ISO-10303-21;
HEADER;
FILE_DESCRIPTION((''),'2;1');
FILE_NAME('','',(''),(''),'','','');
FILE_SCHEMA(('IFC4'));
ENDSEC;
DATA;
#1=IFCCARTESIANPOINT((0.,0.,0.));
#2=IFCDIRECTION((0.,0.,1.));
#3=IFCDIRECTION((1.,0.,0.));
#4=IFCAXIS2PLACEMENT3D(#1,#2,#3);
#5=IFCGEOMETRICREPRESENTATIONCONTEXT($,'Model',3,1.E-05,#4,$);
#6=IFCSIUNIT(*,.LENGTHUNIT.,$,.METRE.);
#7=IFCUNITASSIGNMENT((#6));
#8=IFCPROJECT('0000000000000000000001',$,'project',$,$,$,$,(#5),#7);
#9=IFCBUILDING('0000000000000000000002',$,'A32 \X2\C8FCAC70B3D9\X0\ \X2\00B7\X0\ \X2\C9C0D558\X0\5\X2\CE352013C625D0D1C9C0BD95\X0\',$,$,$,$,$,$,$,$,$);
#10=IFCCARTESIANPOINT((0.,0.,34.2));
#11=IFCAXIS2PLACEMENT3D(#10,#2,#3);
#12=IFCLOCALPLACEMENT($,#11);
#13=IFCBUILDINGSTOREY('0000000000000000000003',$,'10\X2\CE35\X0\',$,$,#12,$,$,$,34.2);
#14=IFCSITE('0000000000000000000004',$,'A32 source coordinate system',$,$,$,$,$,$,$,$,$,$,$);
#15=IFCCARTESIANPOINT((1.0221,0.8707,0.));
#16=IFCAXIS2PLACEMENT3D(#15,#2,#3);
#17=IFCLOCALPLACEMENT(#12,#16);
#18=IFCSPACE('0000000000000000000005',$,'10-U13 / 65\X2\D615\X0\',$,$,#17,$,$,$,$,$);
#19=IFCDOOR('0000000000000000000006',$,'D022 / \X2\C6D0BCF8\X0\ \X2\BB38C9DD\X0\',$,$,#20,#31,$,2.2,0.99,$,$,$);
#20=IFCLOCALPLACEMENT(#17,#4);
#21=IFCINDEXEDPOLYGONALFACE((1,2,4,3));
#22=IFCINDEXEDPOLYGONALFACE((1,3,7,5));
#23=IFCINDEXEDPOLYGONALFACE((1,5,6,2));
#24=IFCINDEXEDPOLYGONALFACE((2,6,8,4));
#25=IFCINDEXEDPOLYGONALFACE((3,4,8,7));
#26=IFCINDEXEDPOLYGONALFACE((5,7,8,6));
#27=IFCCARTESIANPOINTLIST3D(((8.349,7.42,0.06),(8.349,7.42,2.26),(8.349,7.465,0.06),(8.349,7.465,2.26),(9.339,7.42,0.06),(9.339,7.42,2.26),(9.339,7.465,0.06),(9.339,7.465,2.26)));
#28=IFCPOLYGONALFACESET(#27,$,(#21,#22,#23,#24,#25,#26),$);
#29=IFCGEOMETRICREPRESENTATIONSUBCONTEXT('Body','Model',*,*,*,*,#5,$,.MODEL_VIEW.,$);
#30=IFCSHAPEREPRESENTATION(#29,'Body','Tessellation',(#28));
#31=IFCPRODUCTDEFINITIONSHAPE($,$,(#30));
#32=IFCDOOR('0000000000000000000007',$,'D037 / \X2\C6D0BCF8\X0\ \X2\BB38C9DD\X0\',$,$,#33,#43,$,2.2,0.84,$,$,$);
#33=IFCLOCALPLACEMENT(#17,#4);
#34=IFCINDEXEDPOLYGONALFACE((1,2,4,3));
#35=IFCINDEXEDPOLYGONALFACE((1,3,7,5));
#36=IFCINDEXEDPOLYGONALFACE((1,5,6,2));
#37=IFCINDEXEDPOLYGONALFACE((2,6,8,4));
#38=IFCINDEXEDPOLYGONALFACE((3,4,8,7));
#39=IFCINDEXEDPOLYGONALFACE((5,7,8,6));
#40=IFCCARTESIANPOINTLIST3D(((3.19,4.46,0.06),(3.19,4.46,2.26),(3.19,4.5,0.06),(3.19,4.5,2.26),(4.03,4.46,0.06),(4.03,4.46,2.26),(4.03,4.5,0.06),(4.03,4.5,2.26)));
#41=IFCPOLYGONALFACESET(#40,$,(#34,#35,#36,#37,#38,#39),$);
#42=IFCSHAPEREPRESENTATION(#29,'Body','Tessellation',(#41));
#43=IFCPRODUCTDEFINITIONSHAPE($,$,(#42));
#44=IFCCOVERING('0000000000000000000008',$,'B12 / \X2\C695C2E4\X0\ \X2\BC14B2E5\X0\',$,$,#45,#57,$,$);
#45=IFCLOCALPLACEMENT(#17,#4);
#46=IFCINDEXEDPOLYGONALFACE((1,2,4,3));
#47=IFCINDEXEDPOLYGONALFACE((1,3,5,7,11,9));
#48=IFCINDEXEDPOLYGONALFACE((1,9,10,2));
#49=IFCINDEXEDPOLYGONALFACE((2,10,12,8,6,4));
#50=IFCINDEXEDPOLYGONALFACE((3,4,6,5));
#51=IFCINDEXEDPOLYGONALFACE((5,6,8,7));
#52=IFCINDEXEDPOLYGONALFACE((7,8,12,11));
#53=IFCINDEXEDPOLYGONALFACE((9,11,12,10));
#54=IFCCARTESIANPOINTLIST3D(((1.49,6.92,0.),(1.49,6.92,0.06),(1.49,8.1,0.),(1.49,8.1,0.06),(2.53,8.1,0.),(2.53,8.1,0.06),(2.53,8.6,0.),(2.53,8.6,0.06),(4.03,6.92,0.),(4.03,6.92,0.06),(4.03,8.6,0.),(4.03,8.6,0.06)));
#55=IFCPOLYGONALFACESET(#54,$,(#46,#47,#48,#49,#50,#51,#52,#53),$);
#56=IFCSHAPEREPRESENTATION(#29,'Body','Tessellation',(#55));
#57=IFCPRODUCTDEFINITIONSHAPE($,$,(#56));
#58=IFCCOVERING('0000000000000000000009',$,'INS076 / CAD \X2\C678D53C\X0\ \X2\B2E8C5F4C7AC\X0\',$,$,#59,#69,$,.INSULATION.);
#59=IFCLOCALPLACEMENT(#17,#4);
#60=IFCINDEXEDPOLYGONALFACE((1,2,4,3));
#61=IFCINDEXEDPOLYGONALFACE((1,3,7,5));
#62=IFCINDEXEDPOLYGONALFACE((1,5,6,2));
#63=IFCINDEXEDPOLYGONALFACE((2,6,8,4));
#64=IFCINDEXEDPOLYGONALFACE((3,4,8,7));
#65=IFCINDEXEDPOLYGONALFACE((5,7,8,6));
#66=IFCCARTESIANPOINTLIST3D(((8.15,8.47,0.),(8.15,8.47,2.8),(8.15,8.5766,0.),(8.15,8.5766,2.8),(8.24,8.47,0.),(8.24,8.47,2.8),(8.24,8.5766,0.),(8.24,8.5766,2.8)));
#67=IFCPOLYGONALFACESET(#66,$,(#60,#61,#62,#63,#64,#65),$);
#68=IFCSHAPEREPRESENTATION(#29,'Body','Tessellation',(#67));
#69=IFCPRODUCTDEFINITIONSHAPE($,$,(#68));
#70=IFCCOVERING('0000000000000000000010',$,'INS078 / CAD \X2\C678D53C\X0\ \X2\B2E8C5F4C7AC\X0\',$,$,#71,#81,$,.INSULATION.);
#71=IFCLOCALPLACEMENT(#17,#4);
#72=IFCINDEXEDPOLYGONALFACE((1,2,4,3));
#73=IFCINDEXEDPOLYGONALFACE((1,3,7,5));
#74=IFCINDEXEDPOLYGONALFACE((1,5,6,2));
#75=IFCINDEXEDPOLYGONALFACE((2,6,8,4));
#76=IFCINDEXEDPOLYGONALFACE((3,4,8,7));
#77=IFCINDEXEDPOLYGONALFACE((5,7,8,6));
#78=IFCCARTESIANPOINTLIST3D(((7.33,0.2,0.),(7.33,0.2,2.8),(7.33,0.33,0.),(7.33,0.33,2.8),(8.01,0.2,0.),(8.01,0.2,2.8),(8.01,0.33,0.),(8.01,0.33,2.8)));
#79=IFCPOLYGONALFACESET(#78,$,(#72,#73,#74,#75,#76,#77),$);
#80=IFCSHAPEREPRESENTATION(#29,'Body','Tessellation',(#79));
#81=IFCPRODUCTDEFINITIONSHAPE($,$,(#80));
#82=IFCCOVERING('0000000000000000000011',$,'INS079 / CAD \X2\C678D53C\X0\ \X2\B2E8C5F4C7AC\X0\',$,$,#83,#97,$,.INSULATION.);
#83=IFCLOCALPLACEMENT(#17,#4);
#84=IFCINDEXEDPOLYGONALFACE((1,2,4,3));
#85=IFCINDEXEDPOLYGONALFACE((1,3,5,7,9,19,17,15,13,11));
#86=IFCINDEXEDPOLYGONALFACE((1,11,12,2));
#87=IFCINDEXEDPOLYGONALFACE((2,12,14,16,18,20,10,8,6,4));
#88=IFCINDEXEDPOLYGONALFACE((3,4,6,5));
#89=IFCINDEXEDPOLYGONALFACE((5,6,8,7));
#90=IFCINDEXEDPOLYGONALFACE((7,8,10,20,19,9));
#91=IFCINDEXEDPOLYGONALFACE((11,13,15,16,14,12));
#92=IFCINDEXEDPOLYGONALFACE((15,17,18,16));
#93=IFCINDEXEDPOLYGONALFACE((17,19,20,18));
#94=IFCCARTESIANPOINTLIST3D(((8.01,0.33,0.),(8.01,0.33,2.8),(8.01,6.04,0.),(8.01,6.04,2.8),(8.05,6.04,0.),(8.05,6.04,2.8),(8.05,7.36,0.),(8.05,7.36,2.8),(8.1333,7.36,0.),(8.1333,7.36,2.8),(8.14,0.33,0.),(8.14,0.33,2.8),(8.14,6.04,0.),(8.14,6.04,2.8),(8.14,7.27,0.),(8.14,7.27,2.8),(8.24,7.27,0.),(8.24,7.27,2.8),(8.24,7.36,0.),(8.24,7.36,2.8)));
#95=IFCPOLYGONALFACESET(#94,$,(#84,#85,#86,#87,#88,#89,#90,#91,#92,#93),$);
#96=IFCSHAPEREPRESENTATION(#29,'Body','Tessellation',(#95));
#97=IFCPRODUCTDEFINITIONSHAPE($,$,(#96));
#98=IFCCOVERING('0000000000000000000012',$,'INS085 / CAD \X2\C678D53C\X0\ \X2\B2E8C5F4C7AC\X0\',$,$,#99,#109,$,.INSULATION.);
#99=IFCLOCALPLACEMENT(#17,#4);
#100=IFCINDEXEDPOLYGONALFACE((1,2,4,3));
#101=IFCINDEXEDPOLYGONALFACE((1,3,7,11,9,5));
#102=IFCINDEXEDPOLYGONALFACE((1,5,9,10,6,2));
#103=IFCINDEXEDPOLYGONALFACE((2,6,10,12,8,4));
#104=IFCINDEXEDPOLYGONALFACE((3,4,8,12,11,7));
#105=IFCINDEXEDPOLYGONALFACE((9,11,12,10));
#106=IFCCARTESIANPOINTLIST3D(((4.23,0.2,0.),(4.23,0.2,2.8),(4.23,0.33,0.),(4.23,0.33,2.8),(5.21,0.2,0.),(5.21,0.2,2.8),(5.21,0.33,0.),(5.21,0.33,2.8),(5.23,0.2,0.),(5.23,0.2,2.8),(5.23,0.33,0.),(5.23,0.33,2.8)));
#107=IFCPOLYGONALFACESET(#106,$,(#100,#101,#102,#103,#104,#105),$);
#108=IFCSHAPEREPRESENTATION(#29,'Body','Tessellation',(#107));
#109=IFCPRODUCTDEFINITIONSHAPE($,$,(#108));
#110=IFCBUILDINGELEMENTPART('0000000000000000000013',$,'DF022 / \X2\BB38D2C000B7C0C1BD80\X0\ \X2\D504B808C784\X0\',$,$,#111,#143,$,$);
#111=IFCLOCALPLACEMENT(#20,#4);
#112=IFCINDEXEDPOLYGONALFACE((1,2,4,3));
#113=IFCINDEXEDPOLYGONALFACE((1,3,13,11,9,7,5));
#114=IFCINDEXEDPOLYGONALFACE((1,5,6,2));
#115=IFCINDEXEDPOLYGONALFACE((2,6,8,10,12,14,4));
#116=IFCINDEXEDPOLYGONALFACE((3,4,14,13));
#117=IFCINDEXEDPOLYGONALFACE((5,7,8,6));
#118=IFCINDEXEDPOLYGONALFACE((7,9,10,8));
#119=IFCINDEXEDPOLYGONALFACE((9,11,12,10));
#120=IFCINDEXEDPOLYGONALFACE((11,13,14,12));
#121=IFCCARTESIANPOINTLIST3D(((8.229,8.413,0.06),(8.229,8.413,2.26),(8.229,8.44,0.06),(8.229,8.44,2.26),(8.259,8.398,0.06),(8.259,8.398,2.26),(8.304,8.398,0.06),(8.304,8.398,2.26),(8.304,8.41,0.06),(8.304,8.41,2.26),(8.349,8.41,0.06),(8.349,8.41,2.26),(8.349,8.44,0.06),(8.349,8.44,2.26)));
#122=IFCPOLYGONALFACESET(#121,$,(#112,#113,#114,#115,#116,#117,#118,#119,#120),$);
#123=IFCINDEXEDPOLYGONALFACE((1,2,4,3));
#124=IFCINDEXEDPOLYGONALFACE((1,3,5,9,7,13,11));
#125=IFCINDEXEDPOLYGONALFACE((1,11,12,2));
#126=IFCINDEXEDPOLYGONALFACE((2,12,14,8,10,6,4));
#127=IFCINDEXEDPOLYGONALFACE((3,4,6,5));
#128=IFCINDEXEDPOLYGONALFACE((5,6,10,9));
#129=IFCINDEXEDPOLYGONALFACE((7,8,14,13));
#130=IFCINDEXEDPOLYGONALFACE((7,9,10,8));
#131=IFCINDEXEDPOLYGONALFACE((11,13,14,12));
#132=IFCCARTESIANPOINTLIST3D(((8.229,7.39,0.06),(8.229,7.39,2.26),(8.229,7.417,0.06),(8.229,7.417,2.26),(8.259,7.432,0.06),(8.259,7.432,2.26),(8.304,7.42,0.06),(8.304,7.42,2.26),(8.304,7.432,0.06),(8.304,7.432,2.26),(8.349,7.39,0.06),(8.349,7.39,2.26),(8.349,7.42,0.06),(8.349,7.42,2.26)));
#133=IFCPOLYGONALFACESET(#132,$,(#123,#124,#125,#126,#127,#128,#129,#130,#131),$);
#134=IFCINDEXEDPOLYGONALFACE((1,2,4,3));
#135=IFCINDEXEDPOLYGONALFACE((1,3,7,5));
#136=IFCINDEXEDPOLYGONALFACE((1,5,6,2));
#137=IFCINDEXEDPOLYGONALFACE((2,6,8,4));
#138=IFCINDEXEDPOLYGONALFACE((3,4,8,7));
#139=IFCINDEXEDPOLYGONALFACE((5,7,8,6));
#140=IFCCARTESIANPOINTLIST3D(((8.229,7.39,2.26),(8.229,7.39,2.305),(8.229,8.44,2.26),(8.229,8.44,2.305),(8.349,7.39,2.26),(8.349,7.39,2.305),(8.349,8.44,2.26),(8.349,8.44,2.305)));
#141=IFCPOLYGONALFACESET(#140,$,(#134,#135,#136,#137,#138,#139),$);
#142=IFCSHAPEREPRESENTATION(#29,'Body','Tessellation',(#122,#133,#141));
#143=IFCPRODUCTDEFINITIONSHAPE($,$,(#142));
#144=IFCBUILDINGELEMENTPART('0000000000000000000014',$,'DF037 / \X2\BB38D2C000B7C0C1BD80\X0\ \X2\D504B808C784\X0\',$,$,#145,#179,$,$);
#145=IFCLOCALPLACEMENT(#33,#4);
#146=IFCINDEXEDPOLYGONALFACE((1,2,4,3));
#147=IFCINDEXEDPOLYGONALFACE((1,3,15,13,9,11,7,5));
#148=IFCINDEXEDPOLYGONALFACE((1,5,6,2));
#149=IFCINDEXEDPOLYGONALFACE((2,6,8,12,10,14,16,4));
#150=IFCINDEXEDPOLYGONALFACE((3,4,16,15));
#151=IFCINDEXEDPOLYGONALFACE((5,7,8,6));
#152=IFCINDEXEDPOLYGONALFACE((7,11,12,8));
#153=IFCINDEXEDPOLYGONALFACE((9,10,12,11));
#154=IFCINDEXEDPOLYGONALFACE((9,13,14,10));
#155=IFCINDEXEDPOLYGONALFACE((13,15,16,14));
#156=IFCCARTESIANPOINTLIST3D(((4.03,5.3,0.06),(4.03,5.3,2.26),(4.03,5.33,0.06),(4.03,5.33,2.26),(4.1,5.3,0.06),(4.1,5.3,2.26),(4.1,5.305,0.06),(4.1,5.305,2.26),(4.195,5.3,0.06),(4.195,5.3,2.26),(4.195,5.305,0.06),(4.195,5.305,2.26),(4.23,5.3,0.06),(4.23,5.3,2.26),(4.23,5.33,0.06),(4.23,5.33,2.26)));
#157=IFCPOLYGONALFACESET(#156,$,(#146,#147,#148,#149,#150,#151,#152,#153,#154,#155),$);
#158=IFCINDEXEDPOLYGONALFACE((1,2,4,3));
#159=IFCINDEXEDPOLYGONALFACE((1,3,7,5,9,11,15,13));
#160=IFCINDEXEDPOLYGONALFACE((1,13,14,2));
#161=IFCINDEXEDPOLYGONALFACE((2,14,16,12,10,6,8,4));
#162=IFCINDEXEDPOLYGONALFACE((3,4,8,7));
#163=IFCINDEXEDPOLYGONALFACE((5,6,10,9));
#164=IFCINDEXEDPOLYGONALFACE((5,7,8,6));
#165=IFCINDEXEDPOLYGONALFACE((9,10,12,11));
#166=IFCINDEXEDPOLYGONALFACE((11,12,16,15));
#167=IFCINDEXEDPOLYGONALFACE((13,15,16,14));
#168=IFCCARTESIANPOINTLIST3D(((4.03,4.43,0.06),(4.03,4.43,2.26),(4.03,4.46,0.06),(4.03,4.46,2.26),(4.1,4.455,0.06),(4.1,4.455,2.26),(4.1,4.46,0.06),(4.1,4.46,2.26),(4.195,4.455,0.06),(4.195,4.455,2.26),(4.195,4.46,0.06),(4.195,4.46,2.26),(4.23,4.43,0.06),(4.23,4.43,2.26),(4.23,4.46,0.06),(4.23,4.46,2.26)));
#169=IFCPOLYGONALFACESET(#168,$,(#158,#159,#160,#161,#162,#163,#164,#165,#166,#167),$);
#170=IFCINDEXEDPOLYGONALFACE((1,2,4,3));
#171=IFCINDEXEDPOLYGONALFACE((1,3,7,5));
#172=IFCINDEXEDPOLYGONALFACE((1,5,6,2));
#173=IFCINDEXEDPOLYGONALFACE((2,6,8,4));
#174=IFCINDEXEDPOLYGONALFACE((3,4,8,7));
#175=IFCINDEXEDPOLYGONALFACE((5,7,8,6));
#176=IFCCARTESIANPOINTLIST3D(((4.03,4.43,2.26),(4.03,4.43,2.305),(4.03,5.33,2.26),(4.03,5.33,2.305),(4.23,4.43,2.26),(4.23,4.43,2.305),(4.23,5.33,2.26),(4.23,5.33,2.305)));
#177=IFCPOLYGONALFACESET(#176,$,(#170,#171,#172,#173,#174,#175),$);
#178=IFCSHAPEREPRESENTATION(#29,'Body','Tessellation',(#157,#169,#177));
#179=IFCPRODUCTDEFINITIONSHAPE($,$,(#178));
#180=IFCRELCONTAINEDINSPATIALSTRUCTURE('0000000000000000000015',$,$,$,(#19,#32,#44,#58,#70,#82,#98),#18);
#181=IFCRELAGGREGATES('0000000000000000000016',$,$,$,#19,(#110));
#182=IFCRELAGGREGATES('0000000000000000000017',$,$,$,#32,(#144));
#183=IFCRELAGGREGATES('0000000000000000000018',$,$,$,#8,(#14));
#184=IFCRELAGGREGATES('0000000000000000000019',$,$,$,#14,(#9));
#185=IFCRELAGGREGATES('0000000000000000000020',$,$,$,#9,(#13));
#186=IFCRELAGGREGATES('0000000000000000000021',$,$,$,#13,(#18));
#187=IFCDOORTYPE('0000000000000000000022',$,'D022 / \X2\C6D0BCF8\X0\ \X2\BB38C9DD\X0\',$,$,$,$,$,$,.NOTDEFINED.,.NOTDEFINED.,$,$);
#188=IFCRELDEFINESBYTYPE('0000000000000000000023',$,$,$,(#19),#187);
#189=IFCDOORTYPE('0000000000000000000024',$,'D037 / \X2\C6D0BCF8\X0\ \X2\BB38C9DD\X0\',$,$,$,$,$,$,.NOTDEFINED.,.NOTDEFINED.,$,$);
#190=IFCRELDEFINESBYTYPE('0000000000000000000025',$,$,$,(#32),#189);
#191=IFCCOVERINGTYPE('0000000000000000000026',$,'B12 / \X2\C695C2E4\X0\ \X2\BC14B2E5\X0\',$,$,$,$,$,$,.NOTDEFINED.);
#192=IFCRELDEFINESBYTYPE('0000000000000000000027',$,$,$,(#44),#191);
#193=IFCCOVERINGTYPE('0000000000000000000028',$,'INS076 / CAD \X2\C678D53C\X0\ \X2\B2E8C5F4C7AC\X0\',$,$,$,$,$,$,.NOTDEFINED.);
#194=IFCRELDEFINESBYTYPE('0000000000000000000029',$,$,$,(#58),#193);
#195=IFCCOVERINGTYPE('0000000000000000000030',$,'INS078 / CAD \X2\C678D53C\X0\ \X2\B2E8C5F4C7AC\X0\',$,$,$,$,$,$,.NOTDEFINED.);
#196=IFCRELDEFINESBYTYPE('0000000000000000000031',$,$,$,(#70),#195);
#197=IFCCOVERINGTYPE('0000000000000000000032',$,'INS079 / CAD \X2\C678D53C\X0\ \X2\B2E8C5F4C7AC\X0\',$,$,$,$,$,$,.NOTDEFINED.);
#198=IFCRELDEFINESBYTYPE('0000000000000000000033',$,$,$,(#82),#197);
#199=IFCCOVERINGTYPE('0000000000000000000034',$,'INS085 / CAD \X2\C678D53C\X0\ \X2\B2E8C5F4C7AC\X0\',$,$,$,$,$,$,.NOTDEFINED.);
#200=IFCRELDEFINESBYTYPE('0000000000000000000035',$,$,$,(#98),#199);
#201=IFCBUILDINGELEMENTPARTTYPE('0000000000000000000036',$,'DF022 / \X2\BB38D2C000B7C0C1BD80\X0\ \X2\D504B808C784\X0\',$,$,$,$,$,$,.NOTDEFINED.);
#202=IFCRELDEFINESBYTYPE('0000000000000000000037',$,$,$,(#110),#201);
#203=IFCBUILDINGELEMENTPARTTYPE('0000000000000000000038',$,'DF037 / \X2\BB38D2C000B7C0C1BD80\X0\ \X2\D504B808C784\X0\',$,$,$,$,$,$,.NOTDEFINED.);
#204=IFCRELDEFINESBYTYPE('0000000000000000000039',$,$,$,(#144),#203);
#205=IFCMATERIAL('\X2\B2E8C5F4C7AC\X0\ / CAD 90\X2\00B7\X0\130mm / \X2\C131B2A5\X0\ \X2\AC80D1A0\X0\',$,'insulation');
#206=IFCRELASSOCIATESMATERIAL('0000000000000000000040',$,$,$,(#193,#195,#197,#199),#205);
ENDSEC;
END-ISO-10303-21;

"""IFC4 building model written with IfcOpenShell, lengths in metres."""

from ifc_helpers import new_model, si_unit, frame, origin, origin_with_axes, place, context, subcontext, project, spatial, polyline, outline, extrude, source, transform, mapped, material, type_object, type_shapes, element, aggregate, save


model = new_model("IFC4")

# Units and contexts
model_context = context("Model", 3, precision=1e-05, world=origin_with_axes())
body_context = subcontext(model_context, "Body", "Model", "MODEL_VIEW")
ifc_project = project(units=[si_unit("LENGTHUNIT", "METRE")], contexts=[model_context])

# Site, building, storey
site = spatial("IfcSite", under=ifc_project, Name="A32 source coordinate system")
building = spatial("IfcBuilding", under=site, Name="A32 주거동 · 지하5층–옥탑지붕")
storey_placement = place(None, frame((0.0, 0.0, 34.2), z_axis=(0.0, 0.0, 1.0), x_axis=(1.0, 0.0, 0.0)))
storey = spatial("IfcBuildingStorey", under=building, at=storey_placement, Name="10층", Elevation=34.2)

# Shared definitions
space_placement = place(storey_placement, frame((1.0221, 0.8707, 0.0), z_axis=(0.0, 0.0, 1.0), x_axis=(1.0, 0.0, 0.0)))
space = spatial("IfcSpace", under=storey, at=space_placement, Name="10-U13 / 65형")

# Doors
door_type_1 = type_object("IfcDoorType", Name="D022 / 원본 문짝", OperationType="NOTDEFINED", PredefinedType="NOTDEFINED")
shared_shape_1 = source(origin(), body_context, "Body", "SweptSolid", [
    extrude(outline(polyline([(9.339, 7.465), (9.339, 7.42), (8.349, 7.42), (8.349, 7.465), (9.339, 7.465)])), frame((0.0, 0.0, 0.06)), (0.0, 0.0, 1.0), 2.2),
])
type_shapes(door_type_1, [shared_shape_1])
door_1_placement = place(space_placement, origin_with_axes())
door_1 = element("IfcDoor", 1, at=door_1_placement, inside=space, type_object=door_type_1, Name="D022 / 원본 문짝", OverallHeight=2.2, OverallWidth=0.99, context=body_context, shape_type="MappedRepresentation", body=[
    mapped(shared_shape_1, transform((0.0, 0.0, 0.0), scale=1.0)),
])
door_type_2 = type_object("IfcDoorType", Name="D037 / 원본 문짝", OperationType="NOTDEFINED", PredefinedType="NOTDEFINED")
shared_shape_2 = source(origin(), body_context, "Body", "SweptSolid", [
    extrude(outline(polyline([(4.03, 4.46), (3.19, 4.46), (3.19, 4.5), (4.03, 4.5), (4.03, 4.46)])), frame((0.0, 0.0, 0.06)), (0.0, 0.0, 1.0), 2.2),
])
type_shapes(door_type_2, [shared_shape_2])
door_2_placement = place(space_placement, origin_with_axes())
door_2 = element("IfcDoor", 2, at=door_2_placement, inside=space, type_object=door_type_2, Name="D037 / 원본 문짝", OverallHeight=2.2, OverallWidth=0.84, context=body_context, shape_type="MappedRepresentation", body=[
    mapped(shared_shape_2, transform((0.0, 0.0, 0.0), scale=1.0)),
])

# Coverings
covering_type_1 = type_object("IfcCoveringType", Name="B12 / 욕실 바닥", PredefinedType="NOTDEFINED")
shared_shape_3 = source(origin(), body_context, "Body", "SweptSolid", [
    extrude(outline(polyline([(2.53, 8.6), (4.03, 8.6), (4.03, 6.92), (1.49, 6.92), (1.49, 8.1), (2.53, 8.1), (2.53, 8.6)])), origin(), (0.0, 0.0, 1.0), 0.06),
])
type_shapes(covering_type_1, [shared_shape_3])
covering_1_placement = place(space_placement, origin_with_axes())
element("IfcCovering", 3, at=covering_1_placement, inside=space, type_object=covering_type_1, Name="B12 / 욕실 바닥", context=body_context, shape_type="MappedRepresentation", body=[
    mapped(shared_shape_3, transform((0.0, 0.0, 0.0), scale=1.0)),
])
ifc_material = material(Name="단열재 / CAD 90·130mm / 성능 검토", Category="insulation")
covering_type_2 = type_object("IfcCoveringType", Name="INS076 / CAD 외피 단열재", PredefinedType="NOTDEFINED", material=ifc_material)
shared_shape_4 = source(origin(), body_context, "Body", "SweptSolid", [
    extrude(outline(polyline([(8.24, 8.5766), (8.24, 8.47), (8.15, 8.47), (8.15, 8.5766), (8.24, 8.5766)])), origin(), (0.0, 0.0, 1.0), 2.8),
])
type_shapes(covering_type_2, [shared_shape_4])
covering_2_placement = place(space_placement, origin_with_axes())
element("IfcCovering", 4, at=covering_2_placement, inside=space, type_object=covering_type_2, Name="INS076 / CAD 외피 단열재", PredefinedType="INSULATION", context=body_context, shape_type="MappedRepresentation", body=[
    mapped(shared_shape_4, transform((0.0, 0.0, 0.0), scale=1.0)),
])
covering_type_3 = type_object("IfcCoveringType", Name="INS078 / CAD 외피 단열재", PredefinedType="NOTDEFINED", material=ifc_material)
shared_shape_5 = source(origin(), body_context, "Body", "SweptSolid", [
    extrude(outline(polyline([(8.01, 0.2), (7.33, 0.2), (7.33, 0.33), (8.01, 0.33), (8.01, 0.2)])), origin(), (0.0, 0.0, 1.0), 2.8),
])
type_shapes(covering_type_3, [shared_shape_5])
covering_3_placement = place(space_placement, origin_with_axes())
element("IfcCovering", 5, at=covering_3_placement, inside=space, type_object=covering_type_3, Name="INS078 / CAD 외피 단열재", PredefinedType="INSULATION", context=body_context, shape_type="MappedRepresentation", body=[
    mapped(shared_shape_5, transform((0.0, 0.0, 0.0), scale=1.0)),
])
covering_type_4 = type_object("IfcCoveringType", Name="INS079 / CAD 외피 단열재", PredefinedType="NOTDEFINED", material=ifc_material)
shared_shape_6 = source(origin(), body_context, "Body", "SweptSolid", [
    extrude(outline(polyline([(8.24, 7.27), (8.14, 7.27), (8.14, 6.04), (8.14, 0.33), (8.01, 0.33), (8.01, 6.04), (8.05, 6.04), (8.05, 7.36), (8.1333, 7.36), (8.24, 7.36), (8.24, 7.27)])), origin(), (0.0, 0.0, 1.0), 2.8),
])
type_shapes(covering_type_4, [shared_shape_6])
covering_4_placement = place(space_placement, origin_with_axes())
element("IfcCovering", 6, at=covering_4_placement, inside=space, type_object=covering_type_4, Name="INS079 / CAD 외피 단열재", PredefinedType="INSULATION", context=body_context, shape_type="MappedRepresentation", body=[
    mapped(shared_shape_6, transform((0.0, 0.0, 0.0), scale=1.0)),
])
covering_type_5 = type_object("IfcCoveringType", Name="INS085 / CAD 외피 단열재", PredefinedType="NOTDEFINED", material=ifc_material)
shared_shape_7 = source(origin(), body_context, "Body", "SweptSolid", [
    extrude(outline(polyline([(4.23, 0.2), (4.23, 0.33), (5.21, 0.33), (5.23, 0.33), (5.23, 0.2), (5.21, 0.2), (4.23, 0.2)])), origin(), (0.0, 0.0, 1.0), 2.8),
])
type_shapes(covering_type_5, [shared_shape_7])
covering_5_placement = place(space_placement, origin_with_axes())
element("IfcCovering", 7, at=covering_5_placement, inside=space, type_object=covering_type_5, Name="INS085 / CAD 외피 단열재", PredefinedType="INSULATION", context=body_context, shape_type="MappedRepresentation", body=[
    mapped(shared_shape_7, transform((0.0, 0.0, 0.0), scale=1.0)),
])

# Building element parts
building_element_part_type_1 = type_object("IfcBuildingElementPartType", Name="DF022 / 문틀·상부 프레임", PredefinedType="NOTDEFINED")
shared_shape_8 = source(origin(), body_context, "Body", "SweptSolid", [
    extrude(outline(polyline([(8.349, 8.41), (8.304, 8.41), (8.304, 8.398), (8.259, 8.398), (8.229, 8.413), (8.229, 8.44), (8.349, 8.44), (8.349, 8.41)])), frame((0.0, 0.0, 0.06)), (0.0, 0.0, 1.0), 2.2),
    extrude(outline(polyline([(8.229, 7.39), (8.229, 7.417), (8.259, 7.432), (8.304, 7.432), (8.304, 7.42), (8.349, 7.42), (8.349, 7.39), (8.229, 7.39)])), frame((0.0, 0.0, 0.06)), (0.0, 0.0, 1.0), 2.2),
    extrude(outline(polyline([(8.229, 7.39), (8.229, 8.44), (8.349, 8.44), (8.349, 7.39), (8.229, 7.39)])), frame((0.0, 0.0, 2.26)), (0.0, 0.0, 1.0), 0.045),
])
type_shapes(building_element_part_type_1, [shared_shape_8])
building_element_part_1_placement = place(door_1_placement, origin_with_axes())
building_element_part_1 = element("IfcBuildingElementPart", 8, at=building_element_part_1_placement, type_object=building_element_part_type_1, Name="DF022 / 문틀·상부 프레임", context=body_context, shape_type="MappedRepresentation", body=[
    mapped(shared_shape_8, transform((0.0, 0.0, 0.0), scale=1.0)),
])
aggregate(door_1, [building_element_part_1])
building_element_part_type_2 = type_object("IfcBuildingElementPartType", Name="DF037 / 문틀·상부 프레임", PredefinedType="NOTDEFINED")
shared_shape_9 = source(origin(), body_context, "Body", "SweptSolid", [
    extrude(outline(polyline([(4.23, 5.33), (4.23, 5.3), (4.195, 5.3), (4.195, 5.305), (4.1, 5.305), (4.1, 5.3), (4.03, 5.3), (4.03, 5.33), (4.23, 5.33)])), frame((0.0, 0.0, 0.06)), (0.0, 0.0, 1.0), 2.2),
    extrude(outline(polyline([(4.03, 4.46), (4.1, 4.46), (4.1, 4.455), (4.195, 4.455), (4.195, 4.46), (4.23, 4.46), (4.23, 4.43), (4.03, 4.43), (4.03, 4.46)])), frame((0.0, 0.0, 0.06)), (0.0, 0.0, 1.0), 2.2),
    extrude(outline(polyline([(4.03, 4.43), (4.03, 5.33), (4.23, 5.33), (4.23, 4.43), (4.03, 4.43)])), frame((0.0, 0.0, 2.26)), (0.0, 0.0, 1.0), 0.045),
])
type_shapes(building_element_part_type_2, [shared_shape_9])
building_element_part_2_placement = place(door_2_placement, origin_with_axes())
building_element_part_2 = element("IfcBuildingElementPart", 9, at=building_element_part_2_placement, type_object=building_element_part_type_2, Name="DF037 / 문틀·상부 프레임", context=body_context, shape_type="MappedRepresentation", body=[
    mapped(shared_shape_9, transform((0.0, 0.0, 0.0), scale=1.0)),
])
aggregate(door_2, [building_element_part_2])

save(model, "model.ifc")
